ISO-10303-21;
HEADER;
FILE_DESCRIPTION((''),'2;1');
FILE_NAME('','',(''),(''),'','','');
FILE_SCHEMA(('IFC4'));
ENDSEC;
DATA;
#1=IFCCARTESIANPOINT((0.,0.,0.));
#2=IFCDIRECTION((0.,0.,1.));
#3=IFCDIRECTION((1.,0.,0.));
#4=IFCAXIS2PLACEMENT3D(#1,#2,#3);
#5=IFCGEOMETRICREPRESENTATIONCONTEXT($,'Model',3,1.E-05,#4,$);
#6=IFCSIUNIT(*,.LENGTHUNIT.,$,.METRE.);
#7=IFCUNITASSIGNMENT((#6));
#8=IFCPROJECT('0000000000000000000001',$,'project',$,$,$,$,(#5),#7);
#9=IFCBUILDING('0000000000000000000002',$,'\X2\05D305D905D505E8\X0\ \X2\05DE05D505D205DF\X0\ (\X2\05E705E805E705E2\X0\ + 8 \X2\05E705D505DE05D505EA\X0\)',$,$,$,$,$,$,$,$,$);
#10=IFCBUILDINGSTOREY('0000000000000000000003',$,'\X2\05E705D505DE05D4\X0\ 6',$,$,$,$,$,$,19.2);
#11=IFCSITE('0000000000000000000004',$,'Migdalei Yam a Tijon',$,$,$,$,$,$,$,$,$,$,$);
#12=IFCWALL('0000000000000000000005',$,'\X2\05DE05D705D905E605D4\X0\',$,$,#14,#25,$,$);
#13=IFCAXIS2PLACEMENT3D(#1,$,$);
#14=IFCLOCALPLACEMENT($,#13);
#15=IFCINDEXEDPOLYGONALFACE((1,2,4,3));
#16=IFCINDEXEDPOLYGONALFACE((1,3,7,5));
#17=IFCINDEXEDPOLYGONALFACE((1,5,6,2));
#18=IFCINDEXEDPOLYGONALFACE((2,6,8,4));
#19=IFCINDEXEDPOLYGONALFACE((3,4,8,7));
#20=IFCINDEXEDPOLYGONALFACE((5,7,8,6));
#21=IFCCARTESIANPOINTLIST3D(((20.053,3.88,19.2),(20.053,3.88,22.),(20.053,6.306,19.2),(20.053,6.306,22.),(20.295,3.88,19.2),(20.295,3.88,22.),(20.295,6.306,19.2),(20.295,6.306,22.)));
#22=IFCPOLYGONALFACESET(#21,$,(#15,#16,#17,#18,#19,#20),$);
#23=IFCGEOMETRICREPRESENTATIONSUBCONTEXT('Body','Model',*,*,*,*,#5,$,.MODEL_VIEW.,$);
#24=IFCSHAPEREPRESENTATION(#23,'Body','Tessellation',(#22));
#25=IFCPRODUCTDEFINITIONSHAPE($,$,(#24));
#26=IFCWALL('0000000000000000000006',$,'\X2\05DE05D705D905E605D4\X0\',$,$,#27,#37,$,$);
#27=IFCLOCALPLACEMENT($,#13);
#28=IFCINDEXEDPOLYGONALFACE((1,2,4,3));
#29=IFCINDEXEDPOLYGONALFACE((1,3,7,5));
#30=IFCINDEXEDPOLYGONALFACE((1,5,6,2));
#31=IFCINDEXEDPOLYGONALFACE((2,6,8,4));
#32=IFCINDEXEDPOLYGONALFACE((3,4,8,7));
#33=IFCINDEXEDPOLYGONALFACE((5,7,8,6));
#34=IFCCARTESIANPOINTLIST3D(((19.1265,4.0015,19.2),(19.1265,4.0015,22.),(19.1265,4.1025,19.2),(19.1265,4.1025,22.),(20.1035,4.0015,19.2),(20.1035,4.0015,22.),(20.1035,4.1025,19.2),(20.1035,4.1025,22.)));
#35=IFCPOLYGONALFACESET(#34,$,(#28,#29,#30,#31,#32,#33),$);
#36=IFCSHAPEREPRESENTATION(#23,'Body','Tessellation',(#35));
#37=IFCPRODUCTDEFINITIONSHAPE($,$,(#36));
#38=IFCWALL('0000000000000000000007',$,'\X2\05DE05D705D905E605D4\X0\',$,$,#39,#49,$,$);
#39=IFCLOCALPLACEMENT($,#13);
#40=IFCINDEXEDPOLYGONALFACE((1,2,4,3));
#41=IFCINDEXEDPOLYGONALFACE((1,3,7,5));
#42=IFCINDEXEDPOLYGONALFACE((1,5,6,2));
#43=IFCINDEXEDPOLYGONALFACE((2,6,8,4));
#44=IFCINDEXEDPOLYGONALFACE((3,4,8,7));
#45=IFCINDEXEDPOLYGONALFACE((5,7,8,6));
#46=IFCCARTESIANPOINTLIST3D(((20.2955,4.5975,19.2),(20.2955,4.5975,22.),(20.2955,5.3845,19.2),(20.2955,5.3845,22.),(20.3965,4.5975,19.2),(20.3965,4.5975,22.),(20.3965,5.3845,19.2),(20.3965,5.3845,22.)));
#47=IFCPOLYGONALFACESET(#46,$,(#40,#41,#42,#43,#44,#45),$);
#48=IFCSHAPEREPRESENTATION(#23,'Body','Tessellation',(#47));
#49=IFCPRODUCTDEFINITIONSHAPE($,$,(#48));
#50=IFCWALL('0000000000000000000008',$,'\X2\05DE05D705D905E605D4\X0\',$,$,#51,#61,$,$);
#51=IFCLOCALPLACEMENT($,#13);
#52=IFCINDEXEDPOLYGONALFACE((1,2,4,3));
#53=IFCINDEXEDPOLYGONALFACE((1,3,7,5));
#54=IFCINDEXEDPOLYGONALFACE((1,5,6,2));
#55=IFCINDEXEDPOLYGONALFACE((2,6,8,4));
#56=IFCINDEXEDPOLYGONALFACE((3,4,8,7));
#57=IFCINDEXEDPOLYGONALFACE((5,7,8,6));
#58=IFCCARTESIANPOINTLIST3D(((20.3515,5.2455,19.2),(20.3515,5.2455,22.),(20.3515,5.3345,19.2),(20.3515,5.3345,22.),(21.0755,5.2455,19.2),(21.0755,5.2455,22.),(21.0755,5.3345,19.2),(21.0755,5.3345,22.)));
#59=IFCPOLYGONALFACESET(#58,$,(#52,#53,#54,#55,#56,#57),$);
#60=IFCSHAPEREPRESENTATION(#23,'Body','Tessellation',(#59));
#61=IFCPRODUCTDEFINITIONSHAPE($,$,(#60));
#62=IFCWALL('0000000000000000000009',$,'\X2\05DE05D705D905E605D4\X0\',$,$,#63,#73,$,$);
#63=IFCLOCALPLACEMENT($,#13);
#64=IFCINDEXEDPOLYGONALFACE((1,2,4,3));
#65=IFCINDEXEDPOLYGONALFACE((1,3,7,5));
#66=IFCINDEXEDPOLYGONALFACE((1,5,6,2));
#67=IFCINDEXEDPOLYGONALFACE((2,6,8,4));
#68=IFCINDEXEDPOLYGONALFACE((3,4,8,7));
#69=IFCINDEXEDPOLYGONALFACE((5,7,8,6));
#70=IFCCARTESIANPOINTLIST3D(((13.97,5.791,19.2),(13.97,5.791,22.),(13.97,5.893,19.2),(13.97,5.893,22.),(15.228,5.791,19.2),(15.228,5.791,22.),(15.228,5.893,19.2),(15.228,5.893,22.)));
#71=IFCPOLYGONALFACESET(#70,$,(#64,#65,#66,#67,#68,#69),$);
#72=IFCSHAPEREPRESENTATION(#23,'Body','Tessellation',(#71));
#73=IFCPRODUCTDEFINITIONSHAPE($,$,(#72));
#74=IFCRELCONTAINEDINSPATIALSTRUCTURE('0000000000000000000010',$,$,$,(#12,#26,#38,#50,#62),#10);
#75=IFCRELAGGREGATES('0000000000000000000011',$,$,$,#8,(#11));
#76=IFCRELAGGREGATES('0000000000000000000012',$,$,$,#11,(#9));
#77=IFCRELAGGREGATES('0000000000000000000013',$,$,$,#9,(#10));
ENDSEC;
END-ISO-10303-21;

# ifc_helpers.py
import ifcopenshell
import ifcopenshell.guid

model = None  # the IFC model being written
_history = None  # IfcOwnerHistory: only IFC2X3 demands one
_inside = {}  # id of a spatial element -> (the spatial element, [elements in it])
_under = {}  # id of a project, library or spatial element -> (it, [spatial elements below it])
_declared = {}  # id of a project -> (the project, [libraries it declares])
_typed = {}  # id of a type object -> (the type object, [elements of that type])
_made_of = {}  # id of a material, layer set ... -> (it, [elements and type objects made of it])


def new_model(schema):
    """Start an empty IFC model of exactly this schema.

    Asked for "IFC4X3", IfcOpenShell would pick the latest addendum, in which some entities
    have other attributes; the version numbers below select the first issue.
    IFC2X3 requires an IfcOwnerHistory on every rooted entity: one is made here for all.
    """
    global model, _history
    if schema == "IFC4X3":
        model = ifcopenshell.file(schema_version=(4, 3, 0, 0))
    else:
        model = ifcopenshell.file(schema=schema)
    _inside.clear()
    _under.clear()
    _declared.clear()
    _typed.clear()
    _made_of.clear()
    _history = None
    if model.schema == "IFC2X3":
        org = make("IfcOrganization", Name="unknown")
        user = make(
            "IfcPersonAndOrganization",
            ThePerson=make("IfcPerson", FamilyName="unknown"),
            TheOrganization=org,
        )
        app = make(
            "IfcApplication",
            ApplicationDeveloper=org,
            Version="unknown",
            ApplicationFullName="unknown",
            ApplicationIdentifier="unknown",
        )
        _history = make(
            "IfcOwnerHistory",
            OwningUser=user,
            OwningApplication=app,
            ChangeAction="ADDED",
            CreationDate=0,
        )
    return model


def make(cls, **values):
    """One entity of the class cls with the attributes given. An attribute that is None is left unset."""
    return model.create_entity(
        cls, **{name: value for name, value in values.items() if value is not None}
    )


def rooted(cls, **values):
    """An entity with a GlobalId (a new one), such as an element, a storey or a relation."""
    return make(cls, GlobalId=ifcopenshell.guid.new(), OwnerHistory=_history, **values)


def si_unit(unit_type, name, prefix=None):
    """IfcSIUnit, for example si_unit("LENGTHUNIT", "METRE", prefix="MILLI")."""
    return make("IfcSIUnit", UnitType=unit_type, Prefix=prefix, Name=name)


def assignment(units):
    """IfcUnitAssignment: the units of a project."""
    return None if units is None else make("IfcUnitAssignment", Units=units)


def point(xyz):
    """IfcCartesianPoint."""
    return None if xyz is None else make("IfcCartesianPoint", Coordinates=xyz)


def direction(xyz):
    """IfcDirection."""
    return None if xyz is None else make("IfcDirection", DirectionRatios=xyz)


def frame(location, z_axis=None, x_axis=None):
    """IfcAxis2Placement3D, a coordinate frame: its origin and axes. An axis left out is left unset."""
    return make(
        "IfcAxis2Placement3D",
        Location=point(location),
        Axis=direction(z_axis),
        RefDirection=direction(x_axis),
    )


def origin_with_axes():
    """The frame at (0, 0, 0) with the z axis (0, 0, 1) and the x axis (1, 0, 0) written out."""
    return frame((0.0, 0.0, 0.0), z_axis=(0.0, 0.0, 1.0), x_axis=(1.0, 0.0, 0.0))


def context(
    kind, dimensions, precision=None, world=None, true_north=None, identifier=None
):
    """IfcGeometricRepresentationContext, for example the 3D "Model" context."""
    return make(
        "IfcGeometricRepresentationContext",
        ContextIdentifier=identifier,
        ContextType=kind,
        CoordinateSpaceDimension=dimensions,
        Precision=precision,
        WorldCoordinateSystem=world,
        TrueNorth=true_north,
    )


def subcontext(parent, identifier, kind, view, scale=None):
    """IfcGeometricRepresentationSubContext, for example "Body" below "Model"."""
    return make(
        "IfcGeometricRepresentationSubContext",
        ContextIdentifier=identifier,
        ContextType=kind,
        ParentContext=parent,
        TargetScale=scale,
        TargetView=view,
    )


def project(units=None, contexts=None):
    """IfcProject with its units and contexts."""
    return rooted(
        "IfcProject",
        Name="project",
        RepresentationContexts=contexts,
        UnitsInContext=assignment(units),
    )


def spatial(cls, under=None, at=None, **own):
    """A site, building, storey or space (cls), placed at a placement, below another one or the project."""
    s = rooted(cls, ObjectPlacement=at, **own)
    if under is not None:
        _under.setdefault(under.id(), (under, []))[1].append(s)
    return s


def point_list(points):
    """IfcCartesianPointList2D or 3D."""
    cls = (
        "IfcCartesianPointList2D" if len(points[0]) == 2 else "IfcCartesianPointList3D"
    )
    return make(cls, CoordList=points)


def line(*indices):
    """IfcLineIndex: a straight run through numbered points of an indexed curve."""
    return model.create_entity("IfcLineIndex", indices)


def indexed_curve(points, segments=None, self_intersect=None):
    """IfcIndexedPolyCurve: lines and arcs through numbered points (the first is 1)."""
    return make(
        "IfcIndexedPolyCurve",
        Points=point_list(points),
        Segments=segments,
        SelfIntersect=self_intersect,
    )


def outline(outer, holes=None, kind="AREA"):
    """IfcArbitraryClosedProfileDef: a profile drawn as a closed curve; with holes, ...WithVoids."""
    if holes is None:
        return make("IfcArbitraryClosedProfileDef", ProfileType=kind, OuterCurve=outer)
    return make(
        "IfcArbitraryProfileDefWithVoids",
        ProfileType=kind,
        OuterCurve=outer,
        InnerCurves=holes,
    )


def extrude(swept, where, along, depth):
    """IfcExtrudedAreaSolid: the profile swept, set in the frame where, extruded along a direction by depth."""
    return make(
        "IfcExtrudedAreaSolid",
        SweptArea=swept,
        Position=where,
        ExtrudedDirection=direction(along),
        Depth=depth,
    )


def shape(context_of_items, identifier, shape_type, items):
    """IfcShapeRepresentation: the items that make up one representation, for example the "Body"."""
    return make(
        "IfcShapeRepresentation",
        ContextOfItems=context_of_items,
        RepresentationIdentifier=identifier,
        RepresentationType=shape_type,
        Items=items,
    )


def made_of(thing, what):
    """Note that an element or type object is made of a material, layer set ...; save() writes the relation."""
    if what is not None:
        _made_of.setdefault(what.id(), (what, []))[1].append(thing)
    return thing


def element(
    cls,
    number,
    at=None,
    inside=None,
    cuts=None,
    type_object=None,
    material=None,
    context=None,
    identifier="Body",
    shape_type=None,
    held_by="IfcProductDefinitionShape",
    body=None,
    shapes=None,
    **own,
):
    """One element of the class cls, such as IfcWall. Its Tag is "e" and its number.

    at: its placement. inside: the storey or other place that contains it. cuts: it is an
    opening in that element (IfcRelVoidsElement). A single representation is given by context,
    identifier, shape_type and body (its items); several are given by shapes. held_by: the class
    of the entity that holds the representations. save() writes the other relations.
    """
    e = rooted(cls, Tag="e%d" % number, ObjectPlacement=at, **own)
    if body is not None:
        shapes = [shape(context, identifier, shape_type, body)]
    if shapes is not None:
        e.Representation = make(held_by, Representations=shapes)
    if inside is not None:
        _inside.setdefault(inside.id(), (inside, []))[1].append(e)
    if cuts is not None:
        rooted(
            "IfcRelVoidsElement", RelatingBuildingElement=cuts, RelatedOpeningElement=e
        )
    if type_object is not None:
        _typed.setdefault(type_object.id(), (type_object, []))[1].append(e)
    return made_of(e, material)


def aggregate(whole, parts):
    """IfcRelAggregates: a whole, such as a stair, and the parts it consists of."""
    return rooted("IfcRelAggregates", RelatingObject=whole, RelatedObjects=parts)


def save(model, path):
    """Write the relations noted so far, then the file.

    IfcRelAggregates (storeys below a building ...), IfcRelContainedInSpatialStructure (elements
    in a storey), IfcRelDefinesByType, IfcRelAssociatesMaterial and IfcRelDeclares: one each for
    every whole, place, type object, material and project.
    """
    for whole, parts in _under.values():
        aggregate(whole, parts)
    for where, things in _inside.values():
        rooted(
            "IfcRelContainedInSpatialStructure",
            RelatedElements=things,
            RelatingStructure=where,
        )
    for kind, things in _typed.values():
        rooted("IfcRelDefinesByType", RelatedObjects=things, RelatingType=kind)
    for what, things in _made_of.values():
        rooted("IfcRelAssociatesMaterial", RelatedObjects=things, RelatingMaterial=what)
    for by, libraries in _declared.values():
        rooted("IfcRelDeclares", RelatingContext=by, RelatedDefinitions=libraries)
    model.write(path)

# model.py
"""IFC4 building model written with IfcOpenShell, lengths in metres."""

from ifc_helpers import new_model, si_unit, frame, origin_with_axes, context, subcontext, project, spatial, line, indexed_curve, outline, extrude, element, save


model = new_model("IFC4")

# Units and contexts
model_context = context("Model", 3, precision=1e-05, world=origin_with_axes())
body_context = subcontext(model_context, "Body", "Model", "MODEL_VIEW")
ifc_project = project(units=[si_unit("LENGTHUNIT", "METRE")], contexts=[model_context])

# Site, building, storey
site = spatial("IfcSite", under=ifc_project, Name="Migdalei Yam a Tijon")
building = spatial("IfcBuilding", under=site, Name="דיור מוגן (קרקע + 8 קומות)")
storey = spatial("IfcBuildingStorey", under=building, Name="קומה 6", Elevation=19.2)

# Walls
element("IfcWall", 1, inside=storey, Name="מחיצה", context=body_context, shape_type="SweptSolid", body=[
    extrude(outline(indexed_curve([(0.0, 0.0), (0.242, 0.0), (0.242, 2.426), (0.0, 2.426)], segments=[line(1, 2, 3, 4, 1)])), frame((20.053, 3.88, 19.2), z_axis=(0.0, 0.0, 1.0), x_axis=(1.0, 0.0, 0.0)), (0.0, 0.0, 1.0), 2.8),
])
element("IfcWall", 2, inside=storey, Name="מחיצה", context=body_context, shape_type="SweptSolid", body=[
    extrude(outline(indexed_curve([(0.0, 0.0), (0.977, 0.0), (0.977, 0.101), (0.0, 0.101)], segments=[line(1, 2, 3, 4, 1)])), frame((19.1265, 4.0015, 19.2), z_axis=(0.0, 0.0, 1.0), x_axis=(1.0, 0.0, 0.0)), (0.0, 0.0, 1.0), 2.8),
])
element("IfcWall", 3, inside=storey, Name="מחיצה", context=body_context, shape_type="SweptSolid", body=[
    extrude(outline(indexed_curve([(0.0, 0.0), (0.101, 0.0), (0.101, 0.787), (0.0, 0.787)], segments=[line(1, 2, 3, 4, 1)])), frame((20.2955, 4.5975, 19.2), z_axis=(0.0, 0.0, 1.0), x_axis=(1.0, 0.0, 0.0)), (0.0, 0.0, 1.0), 2.8),
])
element("IfcWall", 4, inside=storey, Name="מחיצה", context=body_context, shape_type="SweptSolid", body=[
    extrude(outline(indexed_curve([(0.0, 0.0), (0.724, 0.0), (0.724, 0.089), (0.0, 0.089)], segments=[line(1, 2, 3, 4, 1)])), frame((20.3515, 5.2455, 19.2), z_axis=(0.0, 0.0, 1.0), x_axis=(1.0, 0.0, 0.0)), (0.0, 0.0, 1.0), 2.8),
])
element("IfcWall", 5, inside=storey, Name="מחיצה", context=body_context, shape_type="SweptSolid", body=[
    extrude(outline(indexed_curve([(0.0, 0.0), (1.258, 0.0), (1.258, 0.102), (0.0, 0.102)], segments=[line(1, 2, 3, 4, 1)])), frame((13.97, 5.791, 19.2), z_axis=(0.0, 0.0, 1.0), x_axis=(1.0, 0.0, 0.0)), (0.0, 0.0, 1.0), 2.8),
])

save(model, "model.ifc")
